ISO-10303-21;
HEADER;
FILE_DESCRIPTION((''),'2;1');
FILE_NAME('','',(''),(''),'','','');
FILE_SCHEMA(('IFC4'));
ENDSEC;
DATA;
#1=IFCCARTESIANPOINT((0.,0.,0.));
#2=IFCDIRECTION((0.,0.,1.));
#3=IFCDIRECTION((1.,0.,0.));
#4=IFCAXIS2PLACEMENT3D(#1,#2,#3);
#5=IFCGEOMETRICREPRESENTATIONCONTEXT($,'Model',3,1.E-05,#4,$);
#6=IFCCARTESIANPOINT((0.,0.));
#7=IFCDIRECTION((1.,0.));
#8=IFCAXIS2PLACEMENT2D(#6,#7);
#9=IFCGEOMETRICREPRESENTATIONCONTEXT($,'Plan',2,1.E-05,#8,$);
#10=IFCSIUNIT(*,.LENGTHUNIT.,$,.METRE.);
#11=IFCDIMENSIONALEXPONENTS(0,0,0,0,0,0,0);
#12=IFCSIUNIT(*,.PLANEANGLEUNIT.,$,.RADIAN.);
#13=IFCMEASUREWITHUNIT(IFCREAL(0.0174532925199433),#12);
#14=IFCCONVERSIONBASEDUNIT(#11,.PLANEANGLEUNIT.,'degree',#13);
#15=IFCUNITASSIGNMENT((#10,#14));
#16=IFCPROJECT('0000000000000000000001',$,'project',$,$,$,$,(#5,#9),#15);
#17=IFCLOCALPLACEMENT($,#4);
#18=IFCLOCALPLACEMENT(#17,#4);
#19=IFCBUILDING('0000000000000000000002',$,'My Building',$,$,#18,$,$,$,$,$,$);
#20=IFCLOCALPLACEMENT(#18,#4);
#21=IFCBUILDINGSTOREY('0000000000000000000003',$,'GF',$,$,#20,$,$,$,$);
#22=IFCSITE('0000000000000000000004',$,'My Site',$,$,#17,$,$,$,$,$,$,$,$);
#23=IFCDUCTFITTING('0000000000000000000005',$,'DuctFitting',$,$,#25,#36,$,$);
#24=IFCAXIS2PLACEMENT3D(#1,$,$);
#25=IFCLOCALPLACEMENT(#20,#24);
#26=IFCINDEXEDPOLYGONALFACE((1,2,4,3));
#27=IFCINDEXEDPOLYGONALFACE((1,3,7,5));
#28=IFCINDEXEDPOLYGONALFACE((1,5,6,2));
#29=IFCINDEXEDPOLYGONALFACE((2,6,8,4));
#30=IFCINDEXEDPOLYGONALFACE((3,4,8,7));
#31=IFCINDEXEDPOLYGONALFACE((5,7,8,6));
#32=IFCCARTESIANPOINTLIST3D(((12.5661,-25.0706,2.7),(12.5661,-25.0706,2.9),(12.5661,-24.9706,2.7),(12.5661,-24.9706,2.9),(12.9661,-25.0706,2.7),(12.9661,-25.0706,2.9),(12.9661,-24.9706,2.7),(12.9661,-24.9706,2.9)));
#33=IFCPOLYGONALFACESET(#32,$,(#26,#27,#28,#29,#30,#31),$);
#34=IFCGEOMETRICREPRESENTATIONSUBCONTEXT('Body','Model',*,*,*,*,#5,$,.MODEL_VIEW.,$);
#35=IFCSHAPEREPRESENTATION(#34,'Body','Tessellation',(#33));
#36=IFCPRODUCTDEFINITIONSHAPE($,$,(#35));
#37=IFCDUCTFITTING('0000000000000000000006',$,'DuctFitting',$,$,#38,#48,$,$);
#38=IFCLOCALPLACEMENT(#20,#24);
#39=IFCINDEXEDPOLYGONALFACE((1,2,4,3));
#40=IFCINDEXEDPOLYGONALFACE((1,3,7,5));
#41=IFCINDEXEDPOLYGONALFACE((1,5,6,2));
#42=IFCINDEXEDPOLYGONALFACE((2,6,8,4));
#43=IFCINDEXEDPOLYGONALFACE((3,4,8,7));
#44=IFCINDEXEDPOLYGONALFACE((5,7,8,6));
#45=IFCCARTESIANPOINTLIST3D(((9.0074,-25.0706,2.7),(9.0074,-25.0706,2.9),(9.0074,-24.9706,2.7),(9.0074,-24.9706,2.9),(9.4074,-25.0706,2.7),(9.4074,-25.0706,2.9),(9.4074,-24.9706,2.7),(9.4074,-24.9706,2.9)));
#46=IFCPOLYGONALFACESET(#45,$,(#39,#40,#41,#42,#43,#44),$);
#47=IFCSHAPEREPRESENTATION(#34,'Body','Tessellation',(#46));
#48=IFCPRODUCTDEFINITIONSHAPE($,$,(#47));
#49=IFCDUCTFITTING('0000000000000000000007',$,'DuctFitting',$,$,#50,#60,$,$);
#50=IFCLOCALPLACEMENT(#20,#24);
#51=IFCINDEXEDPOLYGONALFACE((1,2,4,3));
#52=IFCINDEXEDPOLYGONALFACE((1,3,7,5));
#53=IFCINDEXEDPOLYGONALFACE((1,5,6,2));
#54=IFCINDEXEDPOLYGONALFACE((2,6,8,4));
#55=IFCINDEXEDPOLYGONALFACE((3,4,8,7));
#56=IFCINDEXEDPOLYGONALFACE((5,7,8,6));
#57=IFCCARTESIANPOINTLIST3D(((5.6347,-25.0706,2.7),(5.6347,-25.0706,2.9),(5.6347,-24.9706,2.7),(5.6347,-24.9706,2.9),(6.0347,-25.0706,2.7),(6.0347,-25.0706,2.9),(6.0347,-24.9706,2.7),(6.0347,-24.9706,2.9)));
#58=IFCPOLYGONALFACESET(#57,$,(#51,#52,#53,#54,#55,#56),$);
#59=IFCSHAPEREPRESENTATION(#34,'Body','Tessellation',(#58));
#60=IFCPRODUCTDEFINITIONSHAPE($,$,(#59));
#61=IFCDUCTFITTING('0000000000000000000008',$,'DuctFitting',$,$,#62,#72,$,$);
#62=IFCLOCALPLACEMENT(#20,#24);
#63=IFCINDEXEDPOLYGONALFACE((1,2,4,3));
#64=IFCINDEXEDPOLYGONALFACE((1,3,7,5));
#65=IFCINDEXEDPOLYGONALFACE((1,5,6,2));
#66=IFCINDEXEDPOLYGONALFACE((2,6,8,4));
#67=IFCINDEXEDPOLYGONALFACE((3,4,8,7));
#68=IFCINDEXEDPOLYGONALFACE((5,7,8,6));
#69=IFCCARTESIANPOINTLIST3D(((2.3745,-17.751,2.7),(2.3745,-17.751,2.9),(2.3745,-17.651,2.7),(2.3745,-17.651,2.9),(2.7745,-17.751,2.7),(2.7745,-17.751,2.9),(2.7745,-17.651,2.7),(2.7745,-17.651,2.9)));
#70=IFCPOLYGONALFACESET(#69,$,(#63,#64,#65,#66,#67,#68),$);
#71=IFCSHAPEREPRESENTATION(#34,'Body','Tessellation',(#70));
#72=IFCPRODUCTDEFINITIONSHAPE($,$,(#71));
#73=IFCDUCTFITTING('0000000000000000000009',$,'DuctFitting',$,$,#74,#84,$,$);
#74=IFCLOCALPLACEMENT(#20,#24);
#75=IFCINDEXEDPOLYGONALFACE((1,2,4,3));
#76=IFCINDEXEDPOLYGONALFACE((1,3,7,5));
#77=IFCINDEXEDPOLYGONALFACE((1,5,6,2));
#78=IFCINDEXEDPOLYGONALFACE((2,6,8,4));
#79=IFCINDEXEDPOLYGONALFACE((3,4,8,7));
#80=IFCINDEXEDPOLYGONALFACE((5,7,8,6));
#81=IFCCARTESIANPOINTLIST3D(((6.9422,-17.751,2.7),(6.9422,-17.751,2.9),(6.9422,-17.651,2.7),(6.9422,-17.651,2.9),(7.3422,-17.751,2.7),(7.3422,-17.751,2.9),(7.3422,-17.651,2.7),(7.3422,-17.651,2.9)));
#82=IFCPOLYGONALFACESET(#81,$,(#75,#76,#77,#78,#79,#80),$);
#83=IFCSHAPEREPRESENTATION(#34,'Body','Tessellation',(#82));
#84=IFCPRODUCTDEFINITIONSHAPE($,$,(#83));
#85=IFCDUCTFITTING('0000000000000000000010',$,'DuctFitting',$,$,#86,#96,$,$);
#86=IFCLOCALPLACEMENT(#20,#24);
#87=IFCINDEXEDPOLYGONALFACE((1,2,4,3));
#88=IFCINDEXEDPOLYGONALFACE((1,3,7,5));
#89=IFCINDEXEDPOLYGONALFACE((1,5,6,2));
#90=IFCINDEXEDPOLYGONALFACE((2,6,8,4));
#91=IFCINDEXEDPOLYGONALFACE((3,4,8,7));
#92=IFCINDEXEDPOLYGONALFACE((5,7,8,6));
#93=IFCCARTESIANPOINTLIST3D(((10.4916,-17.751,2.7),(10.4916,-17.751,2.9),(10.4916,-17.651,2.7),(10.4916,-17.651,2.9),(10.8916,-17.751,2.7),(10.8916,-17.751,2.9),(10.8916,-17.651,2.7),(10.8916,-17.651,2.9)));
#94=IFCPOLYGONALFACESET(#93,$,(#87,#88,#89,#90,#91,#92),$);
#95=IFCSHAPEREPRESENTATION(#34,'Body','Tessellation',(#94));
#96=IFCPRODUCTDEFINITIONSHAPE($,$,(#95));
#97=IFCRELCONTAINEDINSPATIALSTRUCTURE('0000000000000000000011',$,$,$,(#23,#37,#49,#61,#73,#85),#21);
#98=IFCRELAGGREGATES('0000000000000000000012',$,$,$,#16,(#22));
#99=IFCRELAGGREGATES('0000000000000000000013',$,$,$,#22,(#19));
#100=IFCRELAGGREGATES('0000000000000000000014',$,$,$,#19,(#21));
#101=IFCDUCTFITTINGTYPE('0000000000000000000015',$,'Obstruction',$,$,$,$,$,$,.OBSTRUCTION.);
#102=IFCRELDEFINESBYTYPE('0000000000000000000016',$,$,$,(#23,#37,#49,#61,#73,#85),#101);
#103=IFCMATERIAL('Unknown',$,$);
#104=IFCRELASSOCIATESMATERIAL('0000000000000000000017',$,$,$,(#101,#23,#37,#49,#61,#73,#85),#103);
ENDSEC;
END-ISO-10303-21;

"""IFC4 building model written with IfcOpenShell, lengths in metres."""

from ifc_helpers import new_model, entity, si_unit, converted_unit, frame, origin_with_axes, origin_2d_with_axis, place, context, subcontext, project, spatial, rectangle, extrude, material, material_profile, profile_set, profile_usage, type_object, element, save


model = new_model("IFC4")

# Units and contexts
model_context = context("Model", 3, precision=1e-05, world=origin_with_axes())
plan_context = context("Plan", 2, precision=1e-05, world=origin_2d_with_axis())
body_context_1 = subcontext(model_context, "Body", "Model", "MODEL_VIEW")
ifc_project = project(units=[si_unit("LENGTHUNIT", "METRE"), converted_unit("PLANEANGLEUNIT", "degree", entity("IfcReal", 0.0174532925199433), si_unit("PLANEANGLEUNIT", "RADIAN"), dimensions=[0, 0, 0, 0, 0, 0, 0])], contexts=[model_context, plan_context])

# Site, building, storey
site_placement = place(None, origin_with_axes())
site = spatial("IfcSite", under=ifc_project, at=site_placement, Name="My Site")
building_placement = place(site_placement, origin_with_axes())
building = spatial("IfcBuilding", under=site, at=building_placement, Name="My Building")
storey_placement = place(building_placement, origin_with_axes())
storey = spatial("IfcBuildingStorey", under=building, at=storey_placement, Name="GF")

# Shared definitions
ifc_material = material(Name="Unknown")

# Duct fittings
ifc_material_profile = material_profile(ifc_material, rectangle(XDim=0.4, YDim=0.2))
ifc_profile_set = profile_set([ifc_material_profile])
duct_fitting_type = type_object("IfcDuctFittingType", Name="Obstruction", PredefinedType="OBSTRUCTION", material=ifc_profile_set)
ifc_profile_usage_1 = profile_usage(ifc_profile_set, cardinal=5)
duct_fitting_1_placement = place(storey_placement, frame((12.7661, -25.0706, 2.8), z_axis=(0.0, 1.0, 0.0), x_axis=(-1.0, 0.0, 0.0)))
element("IfcDuctFitting", 1, at=duct_fitting_1_placement, inside=storey, type_object=duct_fitting_type, material=ifc_profile_usage_1, Name="DuctFitting", context=body_context_1, shape_type="SweptSolid", body=[
    extrude(rectangle(XDim=0.4, YDim=0.2), origin_with_axes(), (0.0, 0.0, 1.0), 0.1),
])
ifc_profile_usage_2 = profile_usage(ifc_profile_set, cardinal=5)
duct_fitting_2_placement = place(storey_placement, frame((9.2074, -25.0706, 2.8), z_axis=(0.0, 1.0, 0.0), x_axis=(-1.0, 0.0, 0.0)))
element("IfcDuctFitting", 2, at=duct_fitting_2_placement, inside=storey, type_object=duct_fitting_type, material=ifc_profile_usage_2, Name="DuctFitting", context=body_context_1, shape_type="SweptSolid", body=[
    extrude(rectangle(XDim=0.4, YDim=0.2), origin_with_axes(), (0.0, 0.0, 1.0), 0.1),
])
ifc_profile_usage_3 = profile_usage(ifc_profile_set, cardinal=5)
duct_fitting_3_placement = place(storey_placement, frame((5.8347, -25.0706, 2.8), z_axis=(0.0, 1.0, 0.0), x_axis=(-1.0, 0.0, 0.0)))
element("IfcDuctFitting", 3, at=duct_fitting_3_placement, inside=storey, type_object=duct_fitting_type, material=ifc_profile_usage_3, Name="DuctFitting", context=body_context_1, shape_type="SweptSolid", body=[
    extrude(rectangle(XDim=0.4, YDim=0.2), origin_with_axes(), (0.0, 0.0, 1.0), 0.1),
])
ifc_profile_usage_4 = profile_usage(ifc_profile_set, cardinal=5)
duct_fitting_4_placement = place(storey_placement, frame((2.5745, -17.651, 2.8), z_axis=(0.0, -1.0, 0.0), x_axis=(1.0, 0.0, 0.0)))
element("IfcDuctFitting", 4, at=duct_fitting_4_placement, inside=storey, type_object=duct_fitting_type, material=ifc_profile_usage_4, Name="DuctFitting", context=body_context_1, shape_type="SweptSolid", body=[
    extrude(rectangle(XDim=0.4, YDim=0.2), origin_with_axes(), (0.0, 0.0, 1.0), 0.1),
])
ifc_profile_usage_5 = profile_usage(ifc_profile_set, cardinal=5)
duct_fitting_5_placement = place(storey_placement, frame((7.1422, -17.651, 2.8), z_axis=(0.0, -1.0, 0.0), x_axis=(1.0, 0.0, 0.0)))
element("IfcDuctFitting", 5, at=duct_fitting_5_placement, inside=storey, type_object=duct_fitting_type, material=ifc_profile_usage_5, Name="DuctFitting", context=body_context_1, shape_type="SweptSolid", body=[
    extrude(rectangle(XDim=0.4, YDim=0.2), origin_with_axes(), (0.0, 0.0, 1.0), 0.1),
])
ifc_profile_usage_6 = profile_usage(ifc_profile_set, cardinal=5)
duct_fitting_6_placement = place(storey_placement, frame((10.6916, -17.651, 2.8), z_axis=(0.0, -1.0, 0.0), x_axis=(1.0, 0.0, 0.0)))
element("IfcDuctFitting", 6, at=duct_fitting_6_placement, inside=storey, type_object=duct_fitting_type, material=ifc_profile_usage_6, Name="DuctFitting", context=body_context_1, shape_type="SweptSolid", body=[
    extrude(rectangle(XDim=0.4, YDim=0.2), origin_with_axes(), (0.0, 0.0, 1.0), 0.1),
])

save(model, "model.ifc")
